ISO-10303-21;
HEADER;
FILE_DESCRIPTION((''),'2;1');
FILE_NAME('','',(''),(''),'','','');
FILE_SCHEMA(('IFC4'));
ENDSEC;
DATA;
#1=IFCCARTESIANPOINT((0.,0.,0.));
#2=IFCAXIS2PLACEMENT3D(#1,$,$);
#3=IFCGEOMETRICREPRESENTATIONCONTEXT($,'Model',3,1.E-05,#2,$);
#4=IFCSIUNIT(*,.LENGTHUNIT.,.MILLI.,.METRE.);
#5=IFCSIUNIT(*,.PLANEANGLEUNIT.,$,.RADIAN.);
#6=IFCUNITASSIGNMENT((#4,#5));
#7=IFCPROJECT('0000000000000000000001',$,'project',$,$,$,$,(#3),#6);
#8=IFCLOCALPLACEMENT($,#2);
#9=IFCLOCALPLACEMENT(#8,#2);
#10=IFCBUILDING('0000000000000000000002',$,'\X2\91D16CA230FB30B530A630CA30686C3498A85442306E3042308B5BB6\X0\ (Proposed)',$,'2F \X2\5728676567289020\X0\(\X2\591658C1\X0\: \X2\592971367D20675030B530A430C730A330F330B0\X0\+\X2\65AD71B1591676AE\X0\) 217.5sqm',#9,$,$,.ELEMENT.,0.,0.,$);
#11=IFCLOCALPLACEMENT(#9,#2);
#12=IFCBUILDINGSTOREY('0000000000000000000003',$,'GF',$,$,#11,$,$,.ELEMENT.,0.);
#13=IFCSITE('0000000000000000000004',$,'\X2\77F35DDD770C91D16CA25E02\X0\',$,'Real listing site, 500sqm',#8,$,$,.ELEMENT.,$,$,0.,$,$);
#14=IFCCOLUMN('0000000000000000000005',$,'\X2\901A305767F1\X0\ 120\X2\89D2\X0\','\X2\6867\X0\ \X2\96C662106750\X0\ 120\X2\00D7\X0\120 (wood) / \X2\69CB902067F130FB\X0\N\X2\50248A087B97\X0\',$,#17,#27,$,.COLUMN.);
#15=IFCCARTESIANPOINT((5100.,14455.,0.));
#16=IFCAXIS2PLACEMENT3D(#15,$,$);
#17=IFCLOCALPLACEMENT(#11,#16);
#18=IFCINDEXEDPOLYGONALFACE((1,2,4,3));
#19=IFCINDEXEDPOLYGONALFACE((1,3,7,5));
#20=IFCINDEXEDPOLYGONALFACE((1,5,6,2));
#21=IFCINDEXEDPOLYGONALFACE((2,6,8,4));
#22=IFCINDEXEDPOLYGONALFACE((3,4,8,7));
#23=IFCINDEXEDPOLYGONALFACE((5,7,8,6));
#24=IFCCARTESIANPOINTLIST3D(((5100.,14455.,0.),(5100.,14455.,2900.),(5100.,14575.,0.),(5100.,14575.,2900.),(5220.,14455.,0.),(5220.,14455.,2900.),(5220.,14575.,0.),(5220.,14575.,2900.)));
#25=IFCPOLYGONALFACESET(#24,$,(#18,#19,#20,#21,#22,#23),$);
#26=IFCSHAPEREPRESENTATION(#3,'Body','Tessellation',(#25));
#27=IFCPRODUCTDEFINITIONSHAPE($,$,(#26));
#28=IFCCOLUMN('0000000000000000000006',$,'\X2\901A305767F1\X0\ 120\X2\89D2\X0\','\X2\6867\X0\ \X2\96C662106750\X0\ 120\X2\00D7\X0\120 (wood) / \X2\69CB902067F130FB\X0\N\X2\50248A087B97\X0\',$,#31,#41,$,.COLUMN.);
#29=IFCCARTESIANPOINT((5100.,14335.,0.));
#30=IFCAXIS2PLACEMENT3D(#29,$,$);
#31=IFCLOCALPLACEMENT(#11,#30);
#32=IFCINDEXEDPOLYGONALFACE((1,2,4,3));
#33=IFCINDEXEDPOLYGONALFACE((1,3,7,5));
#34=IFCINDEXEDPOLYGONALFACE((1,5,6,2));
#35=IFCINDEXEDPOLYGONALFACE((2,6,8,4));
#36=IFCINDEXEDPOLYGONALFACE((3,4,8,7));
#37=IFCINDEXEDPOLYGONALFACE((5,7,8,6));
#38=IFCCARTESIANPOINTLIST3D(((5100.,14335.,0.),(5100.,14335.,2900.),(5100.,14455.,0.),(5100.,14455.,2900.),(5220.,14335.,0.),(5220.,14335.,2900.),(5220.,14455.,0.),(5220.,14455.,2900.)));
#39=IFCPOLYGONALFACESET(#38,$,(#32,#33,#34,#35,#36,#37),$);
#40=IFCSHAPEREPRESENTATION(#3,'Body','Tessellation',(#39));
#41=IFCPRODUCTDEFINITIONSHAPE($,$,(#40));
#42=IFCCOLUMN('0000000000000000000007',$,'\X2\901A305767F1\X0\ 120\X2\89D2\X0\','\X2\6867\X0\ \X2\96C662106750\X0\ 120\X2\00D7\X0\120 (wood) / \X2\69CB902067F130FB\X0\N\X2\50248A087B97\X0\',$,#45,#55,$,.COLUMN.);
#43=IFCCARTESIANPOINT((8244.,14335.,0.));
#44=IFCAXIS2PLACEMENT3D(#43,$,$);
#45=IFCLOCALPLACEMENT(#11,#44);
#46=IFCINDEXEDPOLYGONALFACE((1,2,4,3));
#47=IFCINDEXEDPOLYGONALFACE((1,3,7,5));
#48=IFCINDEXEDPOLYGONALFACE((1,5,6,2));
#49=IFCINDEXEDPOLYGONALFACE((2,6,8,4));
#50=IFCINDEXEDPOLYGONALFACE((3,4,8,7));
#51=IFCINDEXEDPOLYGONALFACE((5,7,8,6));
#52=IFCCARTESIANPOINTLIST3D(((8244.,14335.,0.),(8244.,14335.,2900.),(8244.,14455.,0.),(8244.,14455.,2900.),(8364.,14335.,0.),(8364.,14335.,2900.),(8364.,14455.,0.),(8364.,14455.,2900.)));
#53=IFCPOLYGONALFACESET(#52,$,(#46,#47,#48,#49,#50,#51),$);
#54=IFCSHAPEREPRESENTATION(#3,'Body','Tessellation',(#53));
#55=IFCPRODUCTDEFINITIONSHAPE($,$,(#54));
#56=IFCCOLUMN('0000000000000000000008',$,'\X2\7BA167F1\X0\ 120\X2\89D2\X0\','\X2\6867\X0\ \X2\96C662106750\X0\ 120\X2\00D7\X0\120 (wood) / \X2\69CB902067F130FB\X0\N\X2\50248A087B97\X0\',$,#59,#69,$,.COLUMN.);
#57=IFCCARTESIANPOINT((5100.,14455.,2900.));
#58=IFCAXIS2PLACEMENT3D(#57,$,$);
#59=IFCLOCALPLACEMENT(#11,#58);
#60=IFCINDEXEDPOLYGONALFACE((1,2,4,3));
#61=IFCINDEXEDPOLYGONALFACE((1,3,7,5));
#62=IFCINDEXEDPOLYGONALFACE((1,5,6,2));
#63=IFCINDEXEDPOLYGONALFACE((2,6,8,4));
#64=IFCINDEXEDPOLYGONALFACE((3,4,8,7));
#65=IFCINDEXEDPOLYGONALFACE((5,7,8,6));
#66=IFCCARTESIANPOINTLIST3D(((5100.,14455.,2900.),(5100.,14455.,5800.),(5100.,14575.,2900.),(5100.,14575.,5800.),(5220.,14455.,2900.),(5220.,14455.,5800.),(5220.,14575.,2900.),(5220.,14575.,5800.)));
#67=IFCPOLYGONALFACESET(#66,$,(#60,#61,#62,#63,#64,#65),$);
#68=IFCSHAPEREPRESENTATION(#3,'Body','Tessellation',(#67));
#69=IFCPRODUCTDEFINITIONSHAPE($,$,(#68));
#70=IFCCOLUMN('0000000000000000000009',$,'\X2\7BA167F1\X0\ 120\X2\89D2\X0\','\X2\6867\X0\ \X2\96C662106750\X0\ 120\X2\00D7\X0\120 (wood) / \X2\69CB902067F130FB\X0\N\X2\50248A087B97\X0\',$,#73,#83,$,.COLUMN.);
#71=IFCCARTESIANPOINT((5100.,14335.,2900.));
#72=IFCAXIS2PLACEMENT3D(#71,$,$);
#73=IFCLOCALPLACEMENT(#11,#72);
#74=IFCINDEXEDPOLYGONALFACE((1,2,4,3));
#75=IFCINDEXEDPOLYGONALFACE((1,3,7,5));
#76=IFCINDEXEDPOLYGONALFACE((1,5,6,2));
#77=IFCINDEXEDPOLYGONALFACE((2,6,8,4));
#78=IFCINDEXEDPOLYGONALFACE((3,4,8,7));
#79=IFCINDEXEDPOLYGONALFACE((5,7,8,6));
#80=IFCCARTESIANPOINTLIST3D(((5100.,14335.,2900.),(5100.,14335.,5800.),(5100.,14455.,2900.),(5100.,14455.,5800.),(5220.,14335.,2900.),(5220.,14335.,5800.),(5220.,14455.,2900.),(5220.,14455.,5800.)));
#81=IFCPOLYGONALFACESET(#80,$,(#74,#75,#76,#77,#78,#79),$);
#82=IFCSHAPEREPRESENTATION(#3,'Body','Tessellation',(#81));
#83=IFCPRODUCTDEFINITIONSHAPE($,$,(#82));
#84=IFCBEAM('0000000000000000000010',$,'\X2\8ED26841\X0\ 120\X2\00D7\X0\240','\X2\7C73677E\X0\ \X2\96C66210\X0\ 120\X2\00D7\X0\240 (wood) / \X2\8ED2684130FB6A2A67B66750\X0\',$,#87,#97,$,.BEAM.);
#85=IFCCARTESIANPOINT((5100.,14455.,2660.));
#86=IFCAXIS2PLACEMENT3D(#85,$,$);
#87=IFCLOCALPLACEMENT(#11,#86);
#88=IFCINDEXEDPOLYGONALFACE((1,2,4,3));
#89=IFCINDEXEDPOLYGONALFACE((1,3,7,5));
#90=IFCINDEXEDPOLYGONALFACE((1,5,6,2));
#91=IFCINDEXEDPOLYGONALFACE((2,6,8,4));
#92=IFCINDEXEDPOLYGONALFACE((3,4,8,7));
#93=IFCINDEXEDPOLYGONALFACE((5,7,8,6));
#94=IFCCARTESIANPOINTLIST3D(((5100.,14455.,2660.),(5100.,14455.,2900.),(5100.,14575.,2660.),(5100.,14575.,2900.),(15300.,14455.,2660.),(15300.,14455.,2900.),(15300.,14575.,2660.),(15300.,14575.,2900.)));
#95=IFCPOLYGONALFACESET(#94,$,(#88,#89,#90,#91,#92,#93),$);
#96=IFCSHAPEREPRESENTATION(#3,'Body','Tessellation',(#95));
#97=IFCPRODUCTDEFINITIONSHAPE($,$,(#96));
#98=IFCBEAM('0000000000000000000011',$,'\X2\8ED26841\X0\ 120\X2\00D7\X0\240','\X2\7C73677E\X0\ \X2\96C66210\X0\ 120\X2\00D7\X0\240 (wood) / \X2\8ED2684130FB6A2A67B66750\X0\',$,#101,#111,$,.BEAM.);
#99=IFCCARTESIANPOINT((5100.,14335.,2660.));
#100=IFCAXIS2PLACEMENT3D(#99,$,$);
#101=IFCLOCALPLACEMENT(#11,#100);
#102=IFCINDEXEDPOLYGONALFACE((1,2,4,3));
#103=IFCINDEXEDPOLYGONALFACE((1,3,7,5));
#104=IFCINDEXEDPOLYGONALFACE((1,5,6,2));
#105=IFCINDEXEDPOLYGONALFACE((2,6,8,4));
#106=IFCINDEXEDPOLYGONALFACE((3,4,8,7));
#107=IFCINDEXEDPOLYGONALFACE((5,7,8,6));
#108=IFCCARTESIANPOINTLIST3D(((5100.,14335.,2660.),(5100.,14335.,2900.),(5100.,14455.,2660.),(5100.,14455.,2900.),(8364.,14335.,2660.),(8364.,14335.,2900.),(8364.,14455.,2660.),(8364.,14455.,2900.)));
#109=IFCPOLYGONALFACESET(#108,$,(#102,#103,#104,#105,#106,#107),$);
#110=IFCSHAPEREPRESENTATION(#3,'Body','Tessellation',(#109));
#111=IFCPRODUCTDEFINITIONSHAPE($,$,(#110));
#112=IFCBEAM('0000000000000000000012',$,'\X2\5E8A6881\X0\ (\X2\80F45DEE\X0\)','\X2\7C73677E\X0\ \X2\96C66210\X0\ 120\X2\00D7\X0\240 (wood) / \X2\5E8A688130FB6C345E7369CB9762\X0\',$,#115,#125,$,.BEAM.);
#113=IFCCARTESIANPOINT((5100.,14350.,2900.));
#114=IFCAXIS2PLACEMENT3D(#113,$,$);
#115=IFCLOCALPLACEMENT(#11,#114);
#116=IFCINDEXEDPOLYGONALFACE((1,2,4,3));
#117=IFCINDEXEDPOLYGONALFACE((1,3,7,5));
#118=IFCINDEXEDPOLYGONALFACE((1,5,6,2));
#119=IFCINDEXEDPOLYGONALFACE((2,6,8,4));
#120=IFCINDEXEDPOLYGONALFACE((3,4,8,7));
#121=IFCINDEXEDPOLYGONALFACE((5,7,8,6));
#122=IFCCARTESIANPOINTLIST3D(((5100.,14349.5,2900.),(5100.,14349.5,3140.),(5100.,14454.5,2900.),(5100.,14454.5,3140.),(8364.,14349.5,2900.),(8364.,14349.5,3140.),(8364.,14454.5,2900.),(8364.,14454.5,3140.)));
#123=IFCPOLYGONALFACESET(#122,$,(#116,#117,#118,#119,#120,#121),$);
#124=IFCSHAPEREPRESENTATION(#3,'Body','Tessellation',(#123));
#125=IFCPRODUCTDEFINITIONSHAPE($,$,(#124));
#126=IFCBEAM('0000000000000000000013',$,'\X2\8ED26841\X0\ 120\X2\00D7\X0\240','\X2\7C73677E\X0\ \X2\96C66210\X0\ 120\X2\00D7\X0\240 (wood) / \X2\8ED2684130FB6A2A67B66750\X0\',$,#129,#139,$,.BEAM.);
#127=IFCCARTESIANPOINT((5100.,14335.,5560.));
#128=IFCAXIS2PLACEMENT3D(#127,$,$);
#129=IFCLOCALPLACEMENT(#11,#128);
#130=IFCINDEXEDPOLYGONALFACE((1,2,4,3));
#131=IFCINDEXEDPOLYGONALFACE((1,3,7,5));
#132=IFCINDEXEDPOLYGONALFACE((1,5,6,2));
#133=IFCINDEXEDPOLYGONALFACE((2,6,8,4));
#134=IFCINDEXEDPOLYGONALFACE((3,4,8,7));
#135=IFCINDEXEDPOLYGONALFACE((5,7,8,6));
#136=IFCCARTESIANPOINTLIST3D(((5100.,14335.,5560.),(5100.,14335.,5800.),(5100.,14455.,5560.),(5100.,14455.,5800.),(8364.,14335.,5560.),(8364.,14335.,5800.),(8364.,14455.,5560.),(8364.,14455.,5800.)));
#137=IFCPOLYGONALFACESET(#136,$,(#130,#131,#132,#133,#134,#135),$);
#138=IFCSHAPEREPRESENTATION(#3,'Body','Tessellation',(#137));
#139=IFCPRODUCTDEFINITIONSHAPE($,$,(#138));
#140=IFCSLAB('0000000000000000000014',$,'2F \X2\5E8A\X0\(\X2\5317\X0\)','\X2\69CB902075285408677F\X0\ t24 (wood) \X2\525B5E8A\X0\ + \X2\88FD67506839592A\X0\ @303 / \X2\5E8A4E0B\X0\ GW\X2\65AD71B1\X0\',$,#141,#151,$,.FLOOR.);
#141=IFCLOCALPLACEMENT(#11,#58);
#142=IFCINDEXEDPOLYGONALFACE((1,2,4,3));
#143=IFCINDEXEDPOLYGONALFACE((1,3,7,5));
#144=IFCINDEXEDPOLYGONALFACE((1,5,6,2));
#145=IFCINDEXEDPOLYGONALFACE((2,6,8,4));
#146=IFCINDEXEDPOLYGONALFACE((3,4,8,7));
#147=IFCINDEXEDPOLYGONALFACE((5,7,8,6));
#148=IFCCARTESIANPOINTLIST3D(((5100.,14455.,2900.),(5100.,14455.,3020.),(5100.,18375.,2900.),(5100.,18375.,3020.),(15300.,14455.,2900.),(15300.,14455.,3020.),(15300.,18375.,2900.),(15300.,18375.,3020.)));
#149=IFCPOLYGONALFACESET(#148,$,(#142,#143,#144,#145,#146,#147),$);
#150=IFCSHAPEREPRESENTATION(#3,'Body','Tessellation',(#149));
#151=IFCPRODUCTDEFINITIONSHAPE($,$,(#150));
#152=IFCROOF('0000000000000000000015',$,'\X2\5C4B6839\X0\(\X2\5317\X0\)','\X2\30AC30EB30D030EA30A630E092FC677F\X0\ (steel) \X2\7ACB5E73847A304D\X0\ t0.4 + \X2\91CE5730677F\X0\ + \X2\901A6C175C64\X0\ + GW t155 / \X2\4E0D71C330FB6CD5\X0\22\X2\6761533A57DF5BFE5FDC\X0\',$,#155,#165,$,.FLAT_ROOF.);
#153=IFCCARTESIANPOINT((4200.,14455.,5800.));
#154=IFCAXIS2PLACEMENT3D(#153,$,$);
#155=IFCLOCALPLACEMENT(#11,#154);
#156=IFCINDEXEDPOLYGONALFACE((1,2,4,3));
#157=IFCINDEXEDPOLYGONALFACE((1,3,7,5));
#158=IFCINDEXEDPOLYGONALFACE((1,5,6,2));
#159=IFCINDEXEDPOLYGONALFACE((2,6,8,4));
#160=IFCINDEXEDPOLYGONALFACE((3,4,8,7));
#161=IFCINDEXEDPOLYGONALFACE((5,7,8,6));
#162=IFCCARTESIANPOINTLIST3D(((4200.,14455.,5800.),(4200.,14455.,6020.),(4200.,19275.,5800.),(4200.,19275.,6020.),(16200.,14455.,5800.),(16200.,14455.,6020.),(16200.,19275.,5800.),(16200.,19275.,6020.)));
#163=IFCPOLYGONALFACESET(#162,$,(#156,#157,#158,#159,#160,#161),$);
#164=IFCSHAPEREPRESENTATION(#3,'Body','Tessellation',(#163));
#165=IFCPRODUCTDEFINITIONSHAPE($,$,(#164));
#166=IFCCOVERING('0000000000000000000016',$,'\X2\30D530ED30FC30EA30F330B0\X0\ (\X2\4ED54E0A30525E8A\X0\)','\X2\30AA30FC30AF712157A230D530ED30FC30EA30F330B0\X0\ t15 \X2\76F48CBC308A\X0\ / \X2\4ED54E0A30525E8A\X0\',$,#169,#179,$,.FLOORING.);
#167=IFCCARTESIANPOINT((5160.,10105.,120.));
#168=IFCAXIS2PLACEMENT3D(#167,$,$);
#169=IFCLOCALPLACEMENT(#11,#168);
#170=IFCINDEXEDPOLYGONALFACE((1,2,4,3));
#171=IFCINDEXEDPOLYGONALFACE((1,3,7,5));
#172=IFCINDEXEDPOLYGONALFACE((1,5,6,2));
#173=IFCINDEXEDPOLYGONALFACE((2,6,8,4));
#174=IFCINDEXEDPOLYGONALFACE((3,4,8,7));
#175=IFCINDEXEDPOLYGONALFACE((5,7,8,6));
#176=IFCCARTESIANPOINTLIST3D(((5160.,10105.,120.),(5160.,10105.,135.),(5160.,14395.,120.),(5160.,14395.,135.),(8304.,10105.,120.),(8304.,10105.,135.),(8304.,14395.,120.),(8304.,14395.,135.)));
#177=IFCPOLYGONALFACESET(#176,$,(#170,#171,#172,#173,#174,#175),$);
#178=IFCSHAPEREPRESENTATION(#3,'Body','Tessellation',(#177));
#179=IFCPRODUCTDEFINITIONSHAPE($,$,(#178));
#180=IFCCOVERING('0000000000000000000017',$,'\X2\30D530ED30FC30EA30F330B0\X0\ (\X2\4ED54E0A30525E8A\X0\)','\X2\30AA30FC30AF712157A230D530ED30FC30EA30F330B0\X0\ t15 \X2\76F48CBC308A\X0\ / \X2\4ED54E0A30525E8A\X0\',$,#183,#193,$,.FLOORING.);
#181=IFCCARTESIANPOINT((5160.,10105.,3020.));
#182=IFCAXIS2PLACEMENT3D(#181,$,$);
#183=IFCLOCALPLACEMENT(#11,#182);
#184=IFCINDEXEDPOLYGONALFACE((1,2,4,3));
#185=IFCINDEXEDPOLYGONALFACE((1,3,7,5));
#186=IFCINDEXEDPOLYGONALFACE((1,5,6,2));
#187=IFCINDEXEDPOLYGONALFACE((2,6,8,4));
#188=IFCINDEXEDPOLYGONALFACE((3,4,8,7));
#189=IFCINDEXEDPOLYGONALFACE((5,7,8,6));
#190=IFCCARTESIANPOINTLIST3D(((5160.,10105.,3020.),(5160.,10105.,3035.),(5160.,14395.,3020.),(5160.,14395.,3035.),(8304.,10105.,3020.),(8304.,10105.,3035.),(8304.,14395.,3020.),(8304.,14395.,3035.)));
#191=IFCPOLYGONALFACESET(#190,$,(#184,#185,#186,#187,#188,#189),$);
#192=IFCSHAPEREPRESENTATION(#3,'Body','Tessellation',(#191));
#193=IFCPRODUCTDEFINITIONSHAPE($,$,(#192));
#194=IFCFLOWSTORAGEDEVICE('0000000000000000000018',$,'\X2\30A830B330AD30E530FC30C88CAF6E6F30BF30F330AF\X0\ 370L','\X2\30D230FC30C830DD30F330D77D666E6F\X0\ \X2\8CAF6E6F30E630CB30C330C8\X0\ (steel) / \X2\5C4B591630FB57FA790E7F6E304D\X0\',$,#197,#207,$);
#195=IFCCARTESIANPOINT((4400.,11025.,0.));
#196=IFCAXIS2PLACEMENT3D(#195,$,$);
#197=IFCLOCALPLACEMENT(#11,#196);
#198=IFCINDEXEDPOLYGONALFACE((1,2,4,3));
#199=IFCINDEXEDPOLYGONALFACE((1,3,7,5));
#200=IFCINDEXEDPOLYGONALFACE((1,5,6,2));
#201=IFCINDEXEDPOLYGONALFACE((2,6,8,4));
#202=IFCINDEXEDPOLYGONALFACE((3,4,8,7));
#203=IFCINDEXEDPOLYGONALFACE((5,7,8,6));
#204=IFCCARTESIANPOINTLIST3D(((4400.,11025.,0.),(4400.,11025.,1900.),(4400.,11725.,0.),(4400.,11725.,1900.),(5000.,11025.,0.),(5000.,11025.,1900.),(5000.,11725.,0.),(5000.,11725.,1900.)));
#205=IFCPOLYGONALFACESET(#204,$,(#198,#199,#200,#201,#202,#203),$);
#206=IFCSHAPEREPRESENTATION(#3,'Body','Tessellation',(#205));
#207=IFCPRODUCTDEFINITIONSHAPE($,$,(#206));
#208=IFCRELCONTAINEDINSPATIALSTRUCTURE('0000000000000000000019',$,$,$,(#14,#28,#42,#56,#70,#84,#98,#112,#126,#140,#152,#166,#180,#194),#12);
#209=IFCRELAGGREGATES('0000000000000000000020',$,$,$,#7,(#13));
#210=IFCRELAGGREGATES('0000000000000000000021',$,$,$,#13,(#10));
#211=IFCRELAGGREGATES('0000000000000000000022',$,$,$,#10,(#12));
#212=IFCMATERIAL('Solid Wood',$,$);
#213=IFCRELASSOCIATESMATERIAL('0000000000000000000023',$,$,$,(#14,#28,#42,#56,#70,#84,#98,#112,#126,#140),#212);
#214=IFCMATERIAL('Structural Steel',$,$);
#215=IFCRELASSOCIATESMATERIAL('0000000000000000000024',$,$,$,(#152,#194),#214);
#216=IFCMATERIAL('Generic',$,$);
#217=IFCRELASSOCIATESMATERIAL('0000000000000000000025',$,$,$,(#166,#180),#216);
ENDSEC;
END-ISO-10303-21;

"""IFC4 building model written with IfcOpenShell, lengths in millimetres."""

from ifc_helpers import new_model, si_unit, frame, frame_2d, origin, place, context, project, spatial, rectangle, extrude, material, element, save


model = new_model("IFC4")

# Units and contexts
model_context = context("Model", 3, precision=1e-05, world=origin())
ifc_project = project(units=[si_unit("LENGTHUNIT", "METRE", prefix="MILLI"), si_unit("PLANEANGLEUNIT", "RADIAN")], contexts=[model_context])

# Site, building, storey
site_placement = place(None, origin())
site = spatial("IfcSite", under=ifc_project, at=site_placement, Name="石川県金沢市", ObjectType="Real listing site, 500sqm", CompositionType="ELEMENT", RefElevation=0.0)
building_placement = place(site_placement, origin())
building = spatial("IfcBuilding", under=site, at=building_placement, Name="金沢・サウナと水風呂のある家 (Proposed)", ObjectType="2F 在来木造(外壁: 天然素材サイディング+断熱外皮) 217.5sqm", CompositionType="ELEMENT", ElevationOfRefHeight=0.0, ElevationOfTerrain=0.0)
storey_placement = place(building_placement, origin())
storey = spatial("IfcBuildingStorey", under=building, at=storey_placement, Name="GF", CompositionType="ELEMENT", Elevation=0.0)

# Columns
ifc_material_1 = material(Name="Solid Wood")
column_1_placement = place(storey_placement, frame((5100.0, 14455.0, 0.0)))
element("IfcColumn", 1, at=column_1_placement, inside=storey, material=ifc_material_1, Name="通し柱 120角", Description="桧 集成材 120×120 (wood) / 構造柱・N値計算", PredefinedType="COLUMN", context=model_context, shape_type="SweptSolid", body=[
    extrude(rectangle(XDim=120.0, YDim=120.0, at=frame_2d((60.0, 60.0))), frame((5100.0, 14455.0, 0.0)), (0.0, 0.0, 1.0), 2900.0),
])
column_2_placement = place(storey_placement, frame((5100.0, 14335.0, 0.0)))
element("IfcColumn", 2, at=column_2_placement, inside=storey, material=ifc_material_1, Name="通し柱 120角", Description="桧 集成材 120×120 (wood) / 構造柱・N値計算", PredefinedType="COLUMN", context=model_context, shape_type="SweptSolid", body=[
    extrude(rectangle(XDim=120.0, YDim=120.0, at=frame_2d((60.0, 60.0))), frame((5100.0, 14335.0, 0.0)), (0.0, 0.0, 1.0), 2900.0),
])
column_3_placement = place(storey_placement, frame((8244.0, 14335.0, 0.0)))
element("IfcColumn", 3, at=column_3_placement, inside=storey, material=ifc_material_1, Name="通し柱 120角", Description="桧 集成材 120×120 (wood) / 構造柱・N値計算", PredefinedType="COLUMN", context=model_context, shape_type="SweptSolid", body=[
    extrude(rectangle(XDim=120.0, YDim=120.0, at=frame_2d((60.0, 60.0))), frame((8244.0, 14335.0, 0.0)), (0.0, 0.0, 1.0), 2900.0),
])
column_4_placement = place(storey_placement, frame((5100.0, 14455.0, 2900.0)))
element("IfcColumn", 4, at=column_4_placement, inside=storey, material=ifc_material_1, Name="管柱 120角", Description="桧 集成材 120×120 (wood) / 構造柱・N値計算", PredefinedType="COLUMN", context=model_context, shape_type="SweptSolid", body=[
    extrude(rectangle(XDim=120.0, YDim=120.0, at=frame_2d((60.0, 60.0))), frame((5100.0, 14455.0, 2900.0)), (0.0, 0.0, 1.0), 2900.0),
])
column_5_placement = place(storey_placement, frame((5100.0, 14335.0, 2900.0)))
element("IfcColumn", 5, at=column_5_placement, inside=storey, material=ifc_material_1, Name="管柱 120角", Description="桧 集成材 120×120 (wood) / 構造柱・N値計算", PredefinedType="COLUMN", context=model_context, shape_type="SweptSolid", body=[
    extrude(rectangle(XDim=120.0, YDim=120.0, at=frame_2d((60.0, 60.0))), frame((5100.0, 14335.0, 2900.0)), (0.0, 0.0, 1.0), 2900.0),
])

# Beams
beam_1_placement = place(storey_placement, frame((5100.0, 14455.0, 2660.0)))
element("IfcBeam", 6, at=beam_1_placement, inside=storey, material=ifc_material_1, Name="軒桁 120×240", Description="米松 集成 120×240 (wood) / 軒桁・横架材", PredefinedType="BEAM", context=model_context, shape_type="SweptSolid", body=[
    extrude(rectangle(XDim=10200.0, YDim=120.0, at=frame_2d((5100.0, 60.0))), frame((5100.0, 14455.0, 2660.0)), (0.0, 0.0, 1.0), 240.0),
])
beam_2_placement = place(storey_placement, frame((5100.0, 14335.0, 2660.0)))
element("IfcBeam", 7, at=beam_2_placement, inside=storey, material=ifc_material_1, Name="軒桁 120×240", Description="米松 集成 120×240 (wood) / 軒桁・横架材", PredefinedType="BEAM", context=model_context, shape_type="SweptSolid", body=[
    extrude(rectangle(XDim=3264.0, YDim=120.0, at=frame_2d((1632.0, 60.0))), frame((5100.0, 14335.0, 2660.0)), (0.0, 0.0, 1.0), 240.0),
])
beam_3_placement = place(storey_placement, frame((5100.0, 14350.0, 2900.0)))
element("IfcBeam", 8, at=beam_3_placement, inside=storey, material=ifc_material_1, Name="床梁 (胴差)", Description="米松 集成 120×240 (wood) / 床梁・水平構面", PredefinedType="BEAM", context=model_context, shape_type="SweptSolid", body=[
    extrude(rectangle(XDim=3264.0, YDim=105.0, at=frame_2d((1632.0, 52.0))), frame((5100.0, 14350.0, 2900.0)), (0.0, 0.0, 1.0), 240.0),
])
beam_4_placement = place(storey_placement, frame((5100.0, 14335.0, 5560.0)))
element("IfcBeam", 9, at=beam_4_placement, inside=storey, material=ifc_material_1, Name="軒桁 120×240", Description="米松 集成 120×240 (wood) / 軒桁・横架材", PredefinedType="BEAM", context=model_context, shape_type="SweptSolid", body=[
    extrude(rectangle(XDim=3264.0, YDim=120.0, at=frame_2d((1632.0, 60.0))), frame((5100.0, 14335.0, 5560.0)), (0.0, 0.0, 1.0), 240.0),
])

# Slab
slab_1_placement = place(storey_placement, frame((5100.0, 14455.0, 2900.0)))
element("IfcSlab", 10, at=slab_1_placement, inside=storey, material=ifc_material_1, Name="2F 床(北)", Description="構造用合板 t24 (wood) 剛床 + 製材根太 @303 / 床下 GW断熱", PredefinedType="FLOOR", context=model_context, shape_type="SweptSolid", body=[
    extrude(rectangle(XDim=10200.0, YDim=3920.0, at=frame_2d((5100.0, 1960.0))), frame((5100.0, 14455.0, 2900.0)), (0.0, 0.0, 1.0), 120.0),
])

# Roof
ifc_material_2 = material(Name="Structural Steel")
for number, where, name in (
    (11, (4200.0, 14455.0, 5800.0), "屋根(北)"),
):
    element("IfcRoof", number, at=place(storey_placement, frame(where)), inside=storey, material=ifc_material_2, Name=name, Description="ガルバリウム鋼板 (steel) 立平葺き t0.4 + 野地板 + 通気層 + GW t155 / 不燃・法22条区域対応", PredefinedType="FLAT_ROOF", context=model_context, shape_type="SweptSolid", body=[
        extrude(rectangle(XDim=12000.0, YDim=4820.0, at=frame_2d((6000.0, 2410.0))), frame((4200.0, 14455.0, 5800.0)), (0.0, 0.0, 1.0), 220.0),
    ])

# Coverings
ifc_material_3 = material(Name="Generic")
covering_1_placement = place(storey_placement, frame((5160.0, 10105.0, 120.0)))
element("IfcCovering", 12, at=covering_1_placement, inside=storey, material=ifc_material_3, Name="フローリング (仕上げ床)", Description="オーク無垢フローリング t15 直貼り / 仕上げ床", PredefinedType="FLOORING", context=model_context, shape_type="SweptSolid", body=[
    extrude(rectangle(XDim=3144.0, YDim=4290.0, at=frame_2d((1572.0, 2145.0))), frame((5160.0, 10105.0, 120.0)), (0.0, 0.0, 1.0), 15.0),
])
covering_2_placement = place(storey_placement, frame((5160.0, 10105.0, 3020.0)))
element("IfcCovering", 13, at=covering_2_placement, inside=storey, material=ifc_material_3, Name="フローリング (仕上げ床)", Description="オーク無垢フローリング t15 直貼り / 仕上げ床", PredefinedType="FLOORING", context=model_context, shape_type="SweptSolid", body=[
    extrude(rectangle(XDim=3144.0, YDim=4290.0, at=frame_2d((1572.0, 2145.0))), frame((5160.0, 10105.0, 3020.0)), (0.0, 0.0, 1.0), 15.0),
])

# Flow storage device
flow_storage_device_placement = place(storey_placement, frame((4400.0, 11025.0, 0.0)))
element("IfcFlowStorageDevice", 14, at=flow_storage_device_placement, inside=storey, material=ifc_material_2, Name="エコキュート貯湯タンク 370L", Description="ヒートポンプ給湯 貯湯ユニット (steel) / 屋外・基礎置き", context=model_context, shape_type="SweptSolid", body=[
    extrude(rectangle(XDim=600.0, YDim=700.0, at=frame_2d((300.0, 350.0))), frame((4400.0, 11025.0, 0.0)), (0.0, 0.0, 1.0), 1900.0),
])

save(model, "model.ifc")
